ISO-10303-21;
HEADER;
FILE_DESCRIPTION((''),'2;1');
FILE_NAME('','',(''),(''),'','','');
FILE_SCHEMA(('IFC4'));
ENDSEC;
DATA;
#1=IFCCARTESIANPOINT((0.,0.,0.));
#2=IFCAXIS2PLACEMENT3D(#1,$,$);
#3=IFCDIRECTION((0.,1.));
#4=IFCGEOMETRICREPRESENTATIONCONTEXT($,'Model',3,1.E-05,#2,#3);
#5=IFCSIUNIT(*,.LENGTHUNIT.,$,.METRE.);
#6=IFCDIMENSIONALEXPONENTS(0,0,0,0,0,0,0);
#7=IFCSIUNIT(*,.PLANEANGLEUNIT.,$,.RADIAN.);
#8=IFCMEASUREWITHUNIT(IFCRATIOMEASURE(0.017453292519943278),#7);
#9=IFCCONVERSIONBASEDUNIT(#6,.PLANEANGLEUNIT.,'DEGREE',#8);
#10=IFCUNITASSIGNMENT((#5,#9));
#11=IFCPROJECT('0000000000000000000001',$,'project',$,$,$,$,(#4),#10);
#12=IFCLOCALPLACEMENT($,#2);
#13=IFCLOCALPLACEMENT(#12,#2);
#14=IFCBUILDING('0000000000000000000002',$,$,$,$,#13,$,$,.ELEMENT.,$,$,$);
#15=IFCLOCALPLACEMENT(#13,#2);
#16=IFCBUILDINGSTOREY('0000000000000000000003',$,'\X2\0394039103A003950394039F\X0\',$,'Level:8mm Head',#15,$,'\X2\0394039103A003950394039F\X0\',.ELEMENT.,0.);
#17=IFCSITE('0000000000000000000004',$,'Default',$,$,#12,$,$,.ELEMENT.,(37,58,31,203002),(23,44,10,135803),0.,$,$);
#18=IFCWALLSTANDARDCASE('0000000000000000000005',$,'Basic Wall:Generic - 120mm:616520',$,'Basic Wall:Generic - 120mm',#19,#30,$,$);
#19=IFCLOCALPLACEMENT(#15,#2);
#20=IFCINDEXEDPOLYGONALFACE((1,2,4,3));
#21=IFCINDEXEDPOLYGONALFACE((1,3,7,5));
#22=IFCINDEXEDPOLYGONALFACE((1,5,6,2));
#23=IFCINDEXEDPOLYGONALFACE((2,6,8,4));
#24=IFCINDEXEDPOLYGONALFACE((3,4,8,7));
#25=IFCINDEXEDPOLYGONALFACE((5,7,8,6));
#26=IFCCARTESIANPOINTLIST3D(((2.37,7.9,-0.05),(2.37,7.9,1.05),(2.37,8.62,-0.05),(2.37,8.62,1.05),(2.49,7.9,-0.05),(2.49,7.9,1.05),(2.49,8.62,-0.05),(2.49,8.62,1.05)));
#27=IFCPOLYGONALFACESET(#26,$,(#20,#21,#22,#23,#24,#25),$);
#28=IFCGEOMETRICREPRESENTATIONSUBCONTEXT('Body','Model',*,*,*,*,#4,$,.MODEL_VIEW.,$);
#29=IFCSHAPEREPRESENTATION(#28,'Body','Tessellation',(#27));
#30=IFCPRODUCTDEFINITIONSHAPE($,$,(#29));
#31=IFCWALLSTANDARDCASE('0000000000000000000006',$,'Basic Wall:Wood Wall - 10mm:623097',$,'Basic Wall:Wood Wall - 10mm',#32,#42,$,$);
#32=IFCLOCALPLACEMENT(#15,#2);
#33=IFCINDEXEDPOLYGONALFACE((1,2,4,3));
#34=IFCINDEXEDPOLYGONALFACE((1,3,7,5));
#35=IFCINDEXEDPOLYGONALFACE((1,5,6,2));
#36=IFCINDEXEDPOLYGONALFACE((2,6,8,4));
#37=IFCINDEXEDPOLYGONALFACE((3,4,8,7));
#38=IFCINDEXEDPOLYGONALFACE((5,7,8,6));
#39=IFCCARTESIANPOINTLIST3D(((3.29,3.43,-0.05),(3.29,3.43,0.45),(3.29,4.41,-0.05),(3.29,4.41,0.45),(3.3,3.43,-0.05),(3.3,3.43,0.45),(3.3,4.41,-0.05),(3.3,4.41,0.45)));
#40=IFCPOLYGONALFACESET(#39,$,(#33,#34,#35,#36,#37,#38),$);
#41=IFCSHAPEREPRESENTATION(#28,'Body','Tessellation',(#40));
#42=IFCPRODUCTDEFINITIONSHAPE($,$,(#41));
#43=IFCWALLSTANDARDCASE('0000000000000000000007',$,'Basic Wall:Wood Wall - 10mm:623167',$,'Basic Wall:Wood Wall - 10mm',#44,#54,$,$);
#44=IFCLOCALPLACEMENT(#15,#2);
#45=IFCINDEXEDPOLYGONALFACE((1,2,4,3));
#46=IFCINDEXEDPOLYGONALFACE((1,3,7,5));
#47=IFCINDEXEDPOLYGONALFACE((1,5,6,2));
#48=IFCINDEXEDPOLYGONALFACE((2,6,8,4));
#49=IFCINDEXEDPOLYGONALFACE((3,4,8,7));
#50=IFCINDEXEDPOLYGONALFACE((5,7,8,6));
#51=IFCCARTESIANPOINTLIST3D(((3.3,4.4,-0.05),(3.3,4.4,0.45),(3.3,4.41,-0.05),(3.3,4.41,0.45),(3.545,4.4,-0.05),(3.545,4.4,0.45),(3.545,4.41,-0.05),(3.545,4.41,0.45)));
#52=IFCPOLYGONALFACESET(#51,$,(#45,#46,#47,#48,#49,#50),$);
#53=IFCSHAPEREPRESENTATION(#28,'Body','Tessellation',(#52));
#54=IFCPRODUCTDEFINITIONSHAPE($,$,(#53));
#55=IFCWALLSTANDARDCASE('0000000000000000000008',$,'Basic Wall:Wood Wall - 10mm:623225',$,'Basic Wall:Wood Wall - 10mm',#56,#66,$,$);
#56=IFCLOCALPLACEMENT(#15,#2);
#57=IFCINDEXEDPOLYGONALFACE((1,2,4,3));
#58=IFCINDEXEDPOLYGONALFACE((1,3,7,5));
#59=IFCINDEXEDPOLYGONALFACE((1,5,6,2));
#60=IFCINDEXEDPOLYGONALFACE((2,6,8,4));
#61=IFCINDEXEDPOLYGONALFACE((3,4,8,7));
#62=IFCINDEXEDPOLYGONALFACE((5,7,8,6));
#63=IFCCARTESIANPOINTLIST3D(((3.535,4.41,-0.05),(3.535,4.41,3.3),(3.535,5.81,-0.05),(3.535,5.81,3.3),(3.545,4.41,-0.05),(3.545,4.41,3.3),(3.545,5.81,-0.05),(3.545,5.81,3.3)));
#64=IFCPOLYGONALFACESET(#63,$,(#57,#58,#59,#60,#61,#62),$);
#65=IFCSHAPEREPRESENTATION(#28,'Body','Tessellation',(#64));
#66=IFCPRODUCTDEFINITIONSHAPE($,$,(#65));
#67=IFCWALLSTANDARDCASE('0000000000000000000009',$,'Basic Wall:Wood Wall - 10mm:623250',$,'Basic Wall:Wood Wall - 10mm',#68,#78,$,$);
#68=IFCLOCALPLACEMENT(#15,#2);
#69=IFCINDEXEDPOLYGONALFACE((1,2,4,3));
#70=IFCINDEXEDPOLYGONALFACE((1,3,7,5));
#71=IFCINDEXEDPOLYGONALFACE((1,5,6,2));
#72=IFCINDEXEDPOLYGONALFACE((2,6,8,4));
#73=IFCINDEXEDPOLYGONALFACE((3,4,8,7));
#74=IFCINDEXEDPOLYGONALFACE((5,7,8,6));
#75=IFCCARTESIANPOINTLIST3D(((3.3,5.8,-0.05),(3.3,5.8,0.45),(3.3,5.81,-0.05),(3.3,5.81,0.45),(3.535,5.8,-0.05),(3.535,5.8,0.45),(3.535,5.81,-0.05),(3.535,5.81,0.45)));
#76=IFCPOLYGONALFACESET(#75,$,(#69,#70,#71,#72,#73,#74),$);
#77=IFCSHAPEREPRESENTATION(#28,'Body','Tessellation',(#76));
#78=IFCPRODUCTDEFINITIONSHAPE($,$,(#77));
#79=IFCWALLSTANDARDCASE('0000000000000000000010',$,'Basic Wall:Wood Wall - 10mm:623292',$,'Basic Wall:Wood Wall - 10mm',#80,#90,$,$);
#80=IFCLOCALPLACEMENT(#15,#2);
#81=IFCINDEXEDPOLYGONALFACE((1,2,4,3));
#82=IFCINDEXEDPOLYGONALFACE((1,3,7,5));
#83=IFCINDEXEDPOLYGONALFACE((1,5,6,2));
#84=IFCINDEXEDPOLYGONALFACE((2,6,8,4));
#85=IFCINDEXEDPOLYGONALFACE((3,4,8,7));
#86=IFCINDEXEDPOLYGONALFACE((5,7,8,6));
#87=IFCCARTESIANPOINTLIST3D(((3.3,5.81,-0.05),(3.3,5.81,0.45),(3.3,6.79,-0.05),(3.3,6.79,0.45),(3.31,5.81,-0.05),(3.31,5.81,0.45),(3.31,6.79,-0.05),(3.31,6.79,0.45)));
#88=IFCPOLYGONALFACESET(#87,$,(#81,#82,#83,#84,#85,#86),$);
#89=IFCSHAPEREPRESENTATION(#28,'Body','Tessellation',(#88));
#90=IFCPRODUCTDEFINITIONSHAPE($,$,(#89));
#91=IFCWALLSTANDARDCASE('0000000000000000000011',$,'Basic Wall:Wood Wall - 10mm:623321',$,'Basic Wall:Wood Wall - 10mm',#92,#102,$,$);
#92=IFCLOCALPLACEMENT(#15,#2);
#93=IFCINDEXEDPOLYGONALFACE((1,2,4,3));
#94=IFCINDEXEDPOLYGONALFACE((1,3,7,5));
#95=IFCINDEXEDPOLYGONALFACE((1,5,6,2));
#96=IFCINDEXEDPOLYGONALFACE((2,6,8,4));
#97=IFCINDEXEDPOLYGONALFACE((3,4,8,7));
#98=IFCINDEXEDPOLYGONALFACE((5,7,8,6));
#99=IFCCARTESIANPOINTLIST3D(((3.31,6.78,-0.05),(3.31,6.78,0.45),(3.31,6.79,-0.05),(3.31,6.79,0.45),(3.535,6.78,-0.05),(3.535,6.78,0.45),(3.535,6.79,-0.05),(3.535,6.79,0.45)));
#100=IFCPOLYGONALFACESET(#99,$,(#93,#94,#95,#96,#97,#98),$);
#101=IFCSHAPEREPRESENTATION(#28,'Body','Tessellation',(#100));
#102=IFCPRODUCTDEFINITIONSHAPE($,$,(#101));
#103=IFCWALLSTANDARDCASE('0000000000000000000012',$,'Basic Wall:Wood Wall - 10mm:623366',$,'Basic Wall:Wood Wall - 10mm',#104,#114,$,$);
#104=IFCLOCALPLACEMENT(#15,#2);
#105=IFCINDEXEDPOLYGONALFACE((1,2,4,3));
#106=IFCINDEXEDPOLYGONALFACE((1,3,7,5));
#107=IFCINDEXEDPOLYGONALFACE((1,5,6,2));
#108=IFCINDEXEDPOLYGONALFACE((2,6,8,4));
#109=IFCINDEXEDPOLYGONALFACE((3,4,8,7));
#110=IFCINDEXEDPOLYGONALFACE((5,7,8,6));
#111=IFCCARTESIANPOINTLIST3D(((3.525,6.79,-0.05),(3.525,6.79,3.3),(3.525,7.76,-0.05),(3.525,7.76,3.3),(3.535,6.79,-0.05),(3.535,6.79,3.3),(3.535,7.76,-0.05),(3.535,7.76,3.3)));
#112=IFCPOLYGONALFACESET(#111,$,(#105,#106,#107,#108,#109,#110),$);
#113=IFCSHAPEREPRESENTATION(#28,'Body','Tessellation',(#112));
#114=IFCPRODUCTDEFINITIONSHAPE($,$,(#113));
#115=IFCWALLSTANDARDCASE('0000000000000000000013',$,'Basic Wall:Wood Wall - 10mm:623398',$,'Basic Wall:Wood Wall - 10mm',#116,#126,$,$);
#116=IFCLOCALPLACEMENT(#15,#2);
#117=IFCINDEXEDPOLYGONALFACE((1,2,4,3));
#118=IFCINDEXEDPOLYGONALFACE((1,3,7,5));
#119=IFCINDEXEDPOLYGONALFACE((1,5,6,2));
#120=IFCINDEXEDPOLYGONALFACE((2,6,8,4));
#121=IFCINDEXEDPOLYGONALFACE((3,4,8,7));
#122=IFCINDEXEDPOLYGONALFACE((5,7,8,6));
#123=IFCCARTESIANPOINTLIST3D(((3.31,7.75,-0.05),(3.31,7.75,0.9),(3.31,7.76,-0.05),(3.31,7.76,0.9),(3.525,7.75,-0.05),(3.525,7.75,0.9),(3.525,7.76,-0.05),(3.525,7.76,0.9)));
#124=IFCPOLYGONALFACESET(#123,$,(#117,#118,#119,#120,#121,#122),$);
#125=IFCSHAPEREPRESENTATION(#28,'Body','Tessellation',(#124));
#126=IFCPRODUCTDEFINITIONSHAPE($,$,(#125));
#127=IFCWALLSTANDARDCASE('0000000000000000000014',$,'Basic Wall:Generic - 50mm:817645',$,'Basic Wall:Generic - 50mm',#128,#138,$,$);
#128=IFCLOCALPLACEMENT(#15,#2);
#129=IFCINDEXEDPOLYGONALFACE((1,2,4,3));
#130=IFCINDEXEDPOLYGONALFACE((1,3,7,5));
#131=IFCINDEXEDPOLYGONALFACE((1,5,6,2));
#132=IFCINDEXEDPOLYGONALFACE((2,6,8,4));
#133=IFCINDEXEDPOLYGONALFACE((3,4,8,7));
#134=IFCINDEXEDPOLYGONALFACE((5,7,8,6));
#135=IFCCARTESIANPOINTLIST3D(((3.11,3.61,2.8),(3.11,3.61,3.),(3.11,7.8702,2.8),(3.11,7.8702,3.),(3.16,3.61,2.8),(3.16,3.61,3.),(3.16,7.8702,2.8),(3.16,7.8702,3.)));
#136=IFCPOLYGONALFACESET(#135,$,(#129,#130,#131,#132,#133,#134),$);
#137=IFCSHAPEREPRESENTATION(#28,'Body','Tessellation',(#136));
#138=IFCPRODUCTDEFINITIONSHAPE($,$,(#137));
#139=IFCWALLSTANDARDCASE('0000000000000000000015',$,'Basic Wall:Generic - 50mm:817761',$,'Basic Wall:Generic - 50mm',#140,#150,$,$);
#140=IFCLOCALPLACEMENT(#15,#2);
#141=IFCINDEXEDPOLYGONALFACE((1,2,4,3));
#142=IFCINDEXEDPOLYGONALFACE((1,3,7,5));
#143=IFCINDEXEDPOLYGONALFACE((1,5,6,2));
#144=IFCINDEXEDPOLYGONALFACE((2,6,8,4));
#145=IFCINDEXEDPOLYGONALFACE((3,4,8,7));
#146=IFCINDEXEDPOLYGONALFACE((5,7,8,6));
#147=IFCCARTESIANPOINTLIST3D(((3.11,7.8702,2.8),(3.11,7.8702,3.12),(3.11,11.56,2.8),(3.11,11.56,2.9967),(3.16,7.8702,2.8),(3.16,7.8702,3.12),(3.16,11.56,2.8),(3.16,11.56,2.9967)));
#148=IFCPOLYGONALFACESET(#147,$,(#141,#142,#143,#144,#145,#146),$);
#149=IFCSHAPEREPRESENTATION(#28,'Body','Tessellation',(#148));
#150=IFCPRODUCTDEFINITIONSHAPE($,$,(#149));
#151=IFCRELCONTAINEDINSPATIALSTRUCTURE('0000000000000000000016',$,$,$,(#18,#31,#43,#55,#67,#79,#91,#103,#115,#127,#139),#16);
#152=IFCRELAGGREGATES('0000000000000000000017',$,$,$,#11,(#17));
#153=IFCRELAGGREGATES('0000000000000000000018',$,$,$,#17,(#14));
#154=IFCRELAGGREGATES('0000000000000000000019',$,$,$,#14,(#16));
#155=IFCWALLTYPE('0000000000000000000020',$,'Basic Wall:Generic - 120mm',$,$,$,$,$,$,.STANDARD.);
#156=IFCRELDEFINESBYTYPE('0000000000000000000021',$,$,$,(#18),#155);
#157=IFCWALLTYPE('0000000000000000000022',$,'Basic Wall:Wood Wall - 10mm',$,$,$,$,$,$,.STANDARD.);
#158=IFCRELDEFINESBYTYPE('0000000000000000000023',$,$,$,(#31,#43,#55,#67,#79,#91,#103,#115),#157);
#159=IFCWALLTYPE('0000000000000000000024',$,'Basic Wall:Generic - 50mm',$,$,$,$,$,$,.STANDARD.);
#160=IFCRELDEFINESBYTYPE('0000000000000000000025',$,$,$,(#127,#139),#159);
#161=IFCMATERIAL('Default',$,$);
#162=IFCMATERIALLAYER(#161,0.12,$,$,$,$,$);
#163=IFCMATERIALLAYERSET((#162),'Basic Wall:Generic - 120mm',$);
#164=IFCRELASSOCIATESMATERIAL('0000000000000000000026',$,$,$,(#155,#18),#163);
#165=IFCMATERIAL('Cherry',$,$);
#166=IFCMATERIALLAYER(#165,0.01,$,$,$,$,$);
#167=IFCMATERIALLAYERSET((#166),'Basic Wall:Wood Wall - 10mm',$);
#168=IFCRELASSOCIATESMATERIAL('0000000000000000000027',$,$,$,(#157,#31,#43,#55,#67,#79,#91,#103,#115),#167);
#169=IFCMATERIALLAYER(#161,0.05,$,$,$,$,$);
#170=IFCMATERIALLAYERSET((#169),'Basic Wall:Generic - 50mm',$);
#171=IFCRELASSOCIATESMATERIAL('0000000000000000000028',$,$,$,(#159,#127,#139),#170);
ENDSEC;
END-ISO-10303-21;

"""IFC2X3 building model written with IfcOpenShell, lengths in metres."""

from ifc_helpers import new_model, entity, si_unit, converted_unit, direction, frame, frame_2d, origin, place, context, subcontext, project, spatial, polyline, rectangle, extrude, clip, bounded_halfspace, material, layer, layer_set, layer_usage, type_object, element, save


model = new_model("IFC2X3")

# Units and contexts
model_context = context("Model", 3, precision=1e-05, world=origin(), true_north=direction((0.0, 1.0)))
body_context = subcontext(model_context, "Body", "Model", "MODEL_VIEW")
ifc_project = project(units=[si_unit("LENGTHUNIT", "METRE"), converted_unit("PLANEANGLEUNIT", "DEGREE", entity("IfcRatioMeasure", 0.017453292519943278), si_unit("PLANEANGLEUNIT", "RADIAN"), dimensions=[0, 0, 0, 0, 0, 0, 0])], contexts=[model_context])

# Site, building, storey
site_placement = place(None, origin())
site = spatial("IfcSite", under=ifc_project, at=site_placement, Name="Default", CompositionType="ELEMENT", RefLatitude=(37, 58, 31, 203002), RefLongitude=(23, 44, 10, 135803), RefElevation=0.0)
building_placement = place(site_placement, origin())
building = spatial("IfcBuilding", under=site, at=building_placement, CompositionType="ELEMENT")
storey_placement = place(building_placement, origin())
storey = spatial("IfcBuildingStorey", under=building, at=storey_placement, Name="ΔΑΠΕΔΟ", ObjectType="Level:8mm Head", LongName="ΔΑΠΕΔΟ", CompositionType="ELEMENT", Elevation=0.0)

# Walls
ifc_material_1 = material(Name="Default")
ifc_layer_1 = layer(ifc_material_1, 0.12)
ifc_layer_set_1 = layer_set([ifc_layer_1], Name="Basic Wall:Generic - 120mm")
ifc_layer_usage_1 = layer_usage(ifc_layer_set_1, "AXIS2", "POSITIVE", -0.06)
wall_type_1 = type_object("IfcWallType", Name="Basic Wall:Generic - 120mm", PredefinedType="STANDARD", material=ifc_layer_set_1)
wall_1_placement = place(storey_placement, frame((2.43, 7.9, -0.05), z_axis=(0.0, 0.0, 1.0), x_axis=(0.0, 1.0, 0.0)))
element("IfcWallStandardCase", 1, at=wall_1_placement, inside=storey, type_object=wall_type_1, material=ifc_layer_usage_1, Name="Basic Wall:Generic - 120mm:616520", ObjectType="Basic Wall:Generic - 120mm", context=body_context, shape_type="SweptSolid", body=[
    extrude(rectangle(XDim=0.72, YDim=0.12, at=frame_2d((0.36, 0.0), x_axis=(-1.0, 0.0))), origin(), (0.0, 0.0, 1.0), 1.1),
])
ifc_material_2 = material(Name="Cherry")
ifc_layer_2 = layer(ifc_material_2, 0.01)
ifc_layer_set_2 = layer_set([ifc_layer_2], Name="Basic Wall:Wood Wall - 10mm")
ifc_layer_usage_2 = layer_usage(ifc_layer_set_2, "AXIS2", "POSITIVE", -0.005)
wall_type_2 = type_object("IfcWallType", Name="Basic Wall:Wood Wall - 10mm", PredefinedType="STANDARD", material=ifc_layer_set_2)
wall_2_placement = place(storey_placement, frame((3.295, 3.43, -0.05), z_axis=(0.0, 0.0, 1.0), x_axis=(0.0, 1.0, 0.0)))
element("IfcWallStandardCase", 2, at=wall_2_placement, inside=storey, type_object=wall_type_2, material=ifc_layer_usage_2, Name="Basic Wall:Wood Wall - 10mm:623097", ObjectType="Basic Wall:Wood Wall - 10mm", context=body_context, shape_type="Clipping", body=[
    clip(extrude(rectangle(XDim=0.98, YDim=0.01, at=frame_2d((0.49, 0.0), x_axis=(-1.0, 0.0))), origin(), (0.0, 0.0, 1.0), 0.5), bounded_halfspace(frame((0.98, -0.005, 0.0)), True, frame((0.98, -0.005, 0.0)), polyline([(0.0, 0.0), (0.0, 0.01), (-0.98, 0.01), (-0.98, 0.0), (-0.93, 0.0), (-0.01, 0.0), (0.0, 0.0)]))),
])
ifc_layer_usage_3 = layer_usage(ifc_layer_set_2, "AXIS2", "NEGATIVE", 0.005)
wall_3_placement = place(storey_placement, frame((3.3, 4.405, -0.05)))
element("IfcWallStandardCase", 3, at=wall_3_placement, inside=storey, type_object=wall_type_2, material=ifc_layer_usage_3, Name="Basic Wall:Wood Wall - 10mm:623167", ObjectType="Basic Wall:Wood Wall - 10mm", context=body_context, shape_type="Clipping", body=[
    clip(extrude(rectangle(XDim=0.245, YDim=0.01, at=frame_2d((0.1225, 0.0), x_axis=(-1.0, 0.0))), origin(), (0.0, 0.0, 1.0), 0.5), bounded_halfspace(frame((0.245, -0.005, 0.0), z_axis=(0.0, 0.0, 1.0), x_axis=(0.0, 1.0, 0.0)), True, frame((0.245, -0.005, 0.0), z_axis=(0.0, 0.0, 1.0), x_axis=(0.0, 1.0, 0.0)), polyline([(0.0, 0.0), (0.01, 0.0), (0.01, 0.01), (0.01, 0.245), (0.0, 0.245), (0.0, 0.195), (0.0, 0.0)]))),
])
wall_4_placement = place(storey_placement, frame((3.54, 4.41, -0.05), z_axis=(0.0, 0.0, 1.0), x_axis=(0.0, 1.0, 0.0)))
element("IfcWallStandardCase", 4, at=wall_4_placement, inside=storey, type_object=wall_type_2, material=ifc_layer_usage_3, Name="Basic Wall:Wood Wall - 10mm:623225", ObjectType="Basic Wall:Wood Wall - 10mm", context=body_context, shape_type="Clipping", body=[
    clip(extrude(rectangle(XDim=1.4, YDim=0.01, at=frame_2d((0.7, 0.0), x_axis=(-1.0, 0.0))), origin(), (0.0, 0.0, 1.0), 3.35), bounded_halfspace(frame((1.4, -0.005, 0.0)), True, frame((1.4, -0.005, 0.0)), polyline([(0.0, 0.0), (0.0, 0.01), (-0.01, 0.01), (-1.4, 0.01), (-1.4, 0.0), (0.0, 0.0)]))),
])
wall_5_placement = place(storey_placement, frame((3.535, 5.805, -0.05), z_axis=(0.0, 0.0, 1.0), x_axis=(-1.0, 0.0, 0.0)))
element("IfcWallStandardCase", 5, at=wall_5_placement, inside=storey, type_object=wall_type_2, material=ifc_layer_usage_3, Name="Basic Wall:Wood Wall - 10mm:623250", ObjectType="Basic Wall:Wood Wall - 10mm", context=body_context, shape_type="Clipping", body=[
    clip(extrude(rectangle(XDim=0.235, YDim=0.01, at=frame_2d((0.1175, 0.0), x_axis=(-1.0, 0.0))), origin(), (0.0, 0.0, 1.0), 0.5), bounded_halfspace(frame((0.235, -0.005, 0.0), z_axis=(0.0, 0.0, 1.0), x_axis=(0.0, -1.0, 0.0)), True, frame((0.235, -0.005, 0.0), z_axis=(0.0, 0.0, 1.0), x_axis=(0.0, -1.0, 0.0)), polyline([(0.0, 0.0), (-0.01, 0.0), (-0.01, -0.235), (0.0, -0.235), (0.0, -0.01), (0.0, 0.0)]))),
])
wall_6_placement = place(storey_placement, frame((3.305, 5.81, -0.05), z_axis=(0.0, 0.0, 1.0), x_axis=(0.0, 1.0, 0.0)))
element("IfcWallStandardCase", 6, at=wall_6_placement, inside=storey, type_object=wall_type_2, material=ifc_layer_usage_3, Name="Basic Wall:Wood Wall - 10mm:623292", ObjectType="Basic Wall:Wood Wall - 10mm", context=body_context, shape_type="Clipping", body=[
    clip(extrude(rectangle(XDim=0.98, YDim=0.01, at=frame_2d((0.49, 0.0), x_axis=(-1.0, 0.0))), origin(), (0.0, 0.0, 1.0), 0.5), bounded_halfspace(frame((0.98, -0.005, 0.0)), True, frame((0.98, -0.005, 0.0)), polyline([(0.0, 0.0), (0.0, 0.01), (-0.98, 0.01), (-0.98, 0.0), (-0.93, 0.0), (-0.01, 0.0), (0.0, 0.0)]))),
])
wall_7_placement = place(storey_placement, frame((3.31, 6.785, -0.05)))
element("IfcWallStandardCase", 7, at=wall_7_placement, inside=storey, type_object=wall_type_2, material=ifc_layer_usage_3, Name="Basic Wall:Wood Wall - 10mm:623321", ObjectType="Basic Wall:Wood Wall - 10mm", context=body_context, shape_type="Clipping", body=[
    clip(extrude(rectangle(XDim=0.225, YDim=0.01, at=frame_2d((0.1125, 0.0), x_axis=(-1.0, 0.0))), origin(), (0.0, 0.0, 1.0), 0.5), bounded_halfspace(frame((0.225, -0.005, 0.0), z_axis=(0.0, 0.0, 1.0), x_axis=(0.0, 1.0, 0.0)), True, frame((0.225, -0.005, 0.0), z_axis=(0.0, 0.0, 1.0), x_axis=(0.0, 1.0, 0.0)), polyline([(0.0, 0.0), (0.01, 0.0), (0.01, 0.01), (0.01, 0.225), (0.0, 0.225), (0.0, 0.175), (0.0, 0.0)]))),
])
wall_8_placement = place(storey_placement, frame((3.53, 6.79, -0.05), z_axis=(0.0, 0.0, 1.0), x_axis=(0.0, 1.0, 0.0)))
element("IfcWallStandardCase", 8, at=wall_8_placement, inside=storey, type_object=wall_type_2, material=ifc_layer_usage_3, Name="Basic Wall:Wood Wall - 10mm:623366", ObjectType="Basic Wall:Wood Wall - 10mm", context=body_context, shape_type="Clipping", body=[
    clip(extrude(rectangle(XDim=0.97, YDim=0.01, at=frame_2d((0.485, 0.0), x_axis=(-1.0, 0.0))), origin(), (0.0, 0.0, 1.0), 3.35), bounded_halfspace(frame((0.97, -0.005, 0.0)), True, frame((0.97, -0.005, 0.0)), polyline([(0.0, 0.0), (0.0, 0.01), (-0.01, 0.01), (-0.97, 0.01), (-0.97, 0.0), (0.0, 0.0)]))),
])
wall_9_placement = place(storey_placement, frame((3.525, 7.755, -0.05), z_axis=(0.0, 0.0, 1.0), x_axis=(-1.0, 0.0, 0.0)))
element("IfcWallStandardCase", 9, at=wall_9_placement, inside=storey, type_object=wall_type_2, material=ifc_layer_usage_3, Name="Basic Wall:Wood Wall - 10mm:623398", ObjectType="Basic Wall:Wood Wall - 10mm", context=body_context, shape_type="Clipping", body=[
    clip(extrude(rectangle(XDim=0.215, YDim=0.01, at=frame_2d((0.1075, 0.0), x_axis=(-1.0, 0.0))), origin(), (0.0, 0.0, 1.0), 0.95), bounded_halfspace(frame((0.215, -0.005, 0.0), z_axis=(0.0, 0.0, 1.0), x_axis=(0.0, -1.0, 0.0)), True, frame((0.215, -0.005, 0.0), z_axis=(0.0, 0.0, 1.0), x_axis=(0.0, -1.0, 0.0)), polyline([(0.0, 0.0), (-0.01, 0.0), (-0.01, -0.215), (0.0, -0.215), (0.0, -0.06), (0.0, 0.0)]))),
])

# Walls
ifc_layer_3 = layer(ifc_material_1, 0.05)
ifc_layer_set_3 = layer_set([ifc_layer_3], Name="Basic Wall:Generic - 50mm")
ifc_layer_usage_4 = layer_usage(ifc_layer_set_3, "AXIS2", "NEGATIVE", 0.025)
wall_type_3 = type_object("IfcWallType", Name="Basic Wall:Generic - 50mm", PredefinedType="STANDARD", material=ifc_layer_set_3)
wall_10_placement = place(storey_placement, frame((3.135, 3.61, 2.8), z_axis=(0.0, 0.0, 1.0), x_axis=(0.0, 1.0, 0.0)))
element("IfcWallStandardCase", 10, at=wall_10_placement, inside=storey, type_object=wall_type_3, material=ifc_layer_usage_4, Name="Basic Wall:Generic - 50mm:817645", ObjectType="Basic Wall:Generic - 50mm", context=body_context, shape_type="Clipping", body=[
    clip(extrude(rectangle(XDim=4.2602, YDim=0.05, at=frame_2d((2.1301, 0.0), x_axis=(-1.0, 0.0))), origin(), (0.0, 0.0, 1.0), 0.2), bounded_halfspace(frame((0.0, -0.025, 0.2), z_axis=(0.0, 0.0, -1.0), x_axis=(0.0, -1.0, 0.0)), True, frame((0.0, -0.025, 0.2)), polyline([(0.0, 0.0), (4.2602, 0.0), (4.2602, 0.05), (0.0, 0.05), (0.0, 0.0)]))),
])
wall_11_placement = place(storey_placement, frame((3.135, 7.8702, 2.8), z_axis=(0.0, 0.0, 1.0), x_axis=(0.0, 1.0, 0.0)))
element("IfcWallStandardCase", 11, at=wall_11_placement, inside=storey, type_object=wall_type_3, material=ifc_layer_usage_4, Name="Basic Wall:Generic - 50mm:817761", ObjectType="Basic Wall:Generic - 50mm", context=body_context, shape_type="Clipping", body=[
    clip(extrude(rectangle(XDim=3.6898, YDim=0.05, at=frame_2d((1.8449, 0.0), x_axis=(-1.0, 0.0))), origin(), (0.0, 0.0, 1.0), 0.32), bounded_halfspace(frame((0.0, -0.025, 0.32), z_axis=(-0.033402, 0.0, -0.999442), x_axis=(0.999442, 0.0, -0.033402)), True, frame((0.0, -0.025, 0.32)), polyline([(0.0, 0.0), (3.6898, 0.0), (3.6898, 0.05), (0.0, 0.05), (0.0, 0.0)]))),
])

save(model, "model.ifc")
